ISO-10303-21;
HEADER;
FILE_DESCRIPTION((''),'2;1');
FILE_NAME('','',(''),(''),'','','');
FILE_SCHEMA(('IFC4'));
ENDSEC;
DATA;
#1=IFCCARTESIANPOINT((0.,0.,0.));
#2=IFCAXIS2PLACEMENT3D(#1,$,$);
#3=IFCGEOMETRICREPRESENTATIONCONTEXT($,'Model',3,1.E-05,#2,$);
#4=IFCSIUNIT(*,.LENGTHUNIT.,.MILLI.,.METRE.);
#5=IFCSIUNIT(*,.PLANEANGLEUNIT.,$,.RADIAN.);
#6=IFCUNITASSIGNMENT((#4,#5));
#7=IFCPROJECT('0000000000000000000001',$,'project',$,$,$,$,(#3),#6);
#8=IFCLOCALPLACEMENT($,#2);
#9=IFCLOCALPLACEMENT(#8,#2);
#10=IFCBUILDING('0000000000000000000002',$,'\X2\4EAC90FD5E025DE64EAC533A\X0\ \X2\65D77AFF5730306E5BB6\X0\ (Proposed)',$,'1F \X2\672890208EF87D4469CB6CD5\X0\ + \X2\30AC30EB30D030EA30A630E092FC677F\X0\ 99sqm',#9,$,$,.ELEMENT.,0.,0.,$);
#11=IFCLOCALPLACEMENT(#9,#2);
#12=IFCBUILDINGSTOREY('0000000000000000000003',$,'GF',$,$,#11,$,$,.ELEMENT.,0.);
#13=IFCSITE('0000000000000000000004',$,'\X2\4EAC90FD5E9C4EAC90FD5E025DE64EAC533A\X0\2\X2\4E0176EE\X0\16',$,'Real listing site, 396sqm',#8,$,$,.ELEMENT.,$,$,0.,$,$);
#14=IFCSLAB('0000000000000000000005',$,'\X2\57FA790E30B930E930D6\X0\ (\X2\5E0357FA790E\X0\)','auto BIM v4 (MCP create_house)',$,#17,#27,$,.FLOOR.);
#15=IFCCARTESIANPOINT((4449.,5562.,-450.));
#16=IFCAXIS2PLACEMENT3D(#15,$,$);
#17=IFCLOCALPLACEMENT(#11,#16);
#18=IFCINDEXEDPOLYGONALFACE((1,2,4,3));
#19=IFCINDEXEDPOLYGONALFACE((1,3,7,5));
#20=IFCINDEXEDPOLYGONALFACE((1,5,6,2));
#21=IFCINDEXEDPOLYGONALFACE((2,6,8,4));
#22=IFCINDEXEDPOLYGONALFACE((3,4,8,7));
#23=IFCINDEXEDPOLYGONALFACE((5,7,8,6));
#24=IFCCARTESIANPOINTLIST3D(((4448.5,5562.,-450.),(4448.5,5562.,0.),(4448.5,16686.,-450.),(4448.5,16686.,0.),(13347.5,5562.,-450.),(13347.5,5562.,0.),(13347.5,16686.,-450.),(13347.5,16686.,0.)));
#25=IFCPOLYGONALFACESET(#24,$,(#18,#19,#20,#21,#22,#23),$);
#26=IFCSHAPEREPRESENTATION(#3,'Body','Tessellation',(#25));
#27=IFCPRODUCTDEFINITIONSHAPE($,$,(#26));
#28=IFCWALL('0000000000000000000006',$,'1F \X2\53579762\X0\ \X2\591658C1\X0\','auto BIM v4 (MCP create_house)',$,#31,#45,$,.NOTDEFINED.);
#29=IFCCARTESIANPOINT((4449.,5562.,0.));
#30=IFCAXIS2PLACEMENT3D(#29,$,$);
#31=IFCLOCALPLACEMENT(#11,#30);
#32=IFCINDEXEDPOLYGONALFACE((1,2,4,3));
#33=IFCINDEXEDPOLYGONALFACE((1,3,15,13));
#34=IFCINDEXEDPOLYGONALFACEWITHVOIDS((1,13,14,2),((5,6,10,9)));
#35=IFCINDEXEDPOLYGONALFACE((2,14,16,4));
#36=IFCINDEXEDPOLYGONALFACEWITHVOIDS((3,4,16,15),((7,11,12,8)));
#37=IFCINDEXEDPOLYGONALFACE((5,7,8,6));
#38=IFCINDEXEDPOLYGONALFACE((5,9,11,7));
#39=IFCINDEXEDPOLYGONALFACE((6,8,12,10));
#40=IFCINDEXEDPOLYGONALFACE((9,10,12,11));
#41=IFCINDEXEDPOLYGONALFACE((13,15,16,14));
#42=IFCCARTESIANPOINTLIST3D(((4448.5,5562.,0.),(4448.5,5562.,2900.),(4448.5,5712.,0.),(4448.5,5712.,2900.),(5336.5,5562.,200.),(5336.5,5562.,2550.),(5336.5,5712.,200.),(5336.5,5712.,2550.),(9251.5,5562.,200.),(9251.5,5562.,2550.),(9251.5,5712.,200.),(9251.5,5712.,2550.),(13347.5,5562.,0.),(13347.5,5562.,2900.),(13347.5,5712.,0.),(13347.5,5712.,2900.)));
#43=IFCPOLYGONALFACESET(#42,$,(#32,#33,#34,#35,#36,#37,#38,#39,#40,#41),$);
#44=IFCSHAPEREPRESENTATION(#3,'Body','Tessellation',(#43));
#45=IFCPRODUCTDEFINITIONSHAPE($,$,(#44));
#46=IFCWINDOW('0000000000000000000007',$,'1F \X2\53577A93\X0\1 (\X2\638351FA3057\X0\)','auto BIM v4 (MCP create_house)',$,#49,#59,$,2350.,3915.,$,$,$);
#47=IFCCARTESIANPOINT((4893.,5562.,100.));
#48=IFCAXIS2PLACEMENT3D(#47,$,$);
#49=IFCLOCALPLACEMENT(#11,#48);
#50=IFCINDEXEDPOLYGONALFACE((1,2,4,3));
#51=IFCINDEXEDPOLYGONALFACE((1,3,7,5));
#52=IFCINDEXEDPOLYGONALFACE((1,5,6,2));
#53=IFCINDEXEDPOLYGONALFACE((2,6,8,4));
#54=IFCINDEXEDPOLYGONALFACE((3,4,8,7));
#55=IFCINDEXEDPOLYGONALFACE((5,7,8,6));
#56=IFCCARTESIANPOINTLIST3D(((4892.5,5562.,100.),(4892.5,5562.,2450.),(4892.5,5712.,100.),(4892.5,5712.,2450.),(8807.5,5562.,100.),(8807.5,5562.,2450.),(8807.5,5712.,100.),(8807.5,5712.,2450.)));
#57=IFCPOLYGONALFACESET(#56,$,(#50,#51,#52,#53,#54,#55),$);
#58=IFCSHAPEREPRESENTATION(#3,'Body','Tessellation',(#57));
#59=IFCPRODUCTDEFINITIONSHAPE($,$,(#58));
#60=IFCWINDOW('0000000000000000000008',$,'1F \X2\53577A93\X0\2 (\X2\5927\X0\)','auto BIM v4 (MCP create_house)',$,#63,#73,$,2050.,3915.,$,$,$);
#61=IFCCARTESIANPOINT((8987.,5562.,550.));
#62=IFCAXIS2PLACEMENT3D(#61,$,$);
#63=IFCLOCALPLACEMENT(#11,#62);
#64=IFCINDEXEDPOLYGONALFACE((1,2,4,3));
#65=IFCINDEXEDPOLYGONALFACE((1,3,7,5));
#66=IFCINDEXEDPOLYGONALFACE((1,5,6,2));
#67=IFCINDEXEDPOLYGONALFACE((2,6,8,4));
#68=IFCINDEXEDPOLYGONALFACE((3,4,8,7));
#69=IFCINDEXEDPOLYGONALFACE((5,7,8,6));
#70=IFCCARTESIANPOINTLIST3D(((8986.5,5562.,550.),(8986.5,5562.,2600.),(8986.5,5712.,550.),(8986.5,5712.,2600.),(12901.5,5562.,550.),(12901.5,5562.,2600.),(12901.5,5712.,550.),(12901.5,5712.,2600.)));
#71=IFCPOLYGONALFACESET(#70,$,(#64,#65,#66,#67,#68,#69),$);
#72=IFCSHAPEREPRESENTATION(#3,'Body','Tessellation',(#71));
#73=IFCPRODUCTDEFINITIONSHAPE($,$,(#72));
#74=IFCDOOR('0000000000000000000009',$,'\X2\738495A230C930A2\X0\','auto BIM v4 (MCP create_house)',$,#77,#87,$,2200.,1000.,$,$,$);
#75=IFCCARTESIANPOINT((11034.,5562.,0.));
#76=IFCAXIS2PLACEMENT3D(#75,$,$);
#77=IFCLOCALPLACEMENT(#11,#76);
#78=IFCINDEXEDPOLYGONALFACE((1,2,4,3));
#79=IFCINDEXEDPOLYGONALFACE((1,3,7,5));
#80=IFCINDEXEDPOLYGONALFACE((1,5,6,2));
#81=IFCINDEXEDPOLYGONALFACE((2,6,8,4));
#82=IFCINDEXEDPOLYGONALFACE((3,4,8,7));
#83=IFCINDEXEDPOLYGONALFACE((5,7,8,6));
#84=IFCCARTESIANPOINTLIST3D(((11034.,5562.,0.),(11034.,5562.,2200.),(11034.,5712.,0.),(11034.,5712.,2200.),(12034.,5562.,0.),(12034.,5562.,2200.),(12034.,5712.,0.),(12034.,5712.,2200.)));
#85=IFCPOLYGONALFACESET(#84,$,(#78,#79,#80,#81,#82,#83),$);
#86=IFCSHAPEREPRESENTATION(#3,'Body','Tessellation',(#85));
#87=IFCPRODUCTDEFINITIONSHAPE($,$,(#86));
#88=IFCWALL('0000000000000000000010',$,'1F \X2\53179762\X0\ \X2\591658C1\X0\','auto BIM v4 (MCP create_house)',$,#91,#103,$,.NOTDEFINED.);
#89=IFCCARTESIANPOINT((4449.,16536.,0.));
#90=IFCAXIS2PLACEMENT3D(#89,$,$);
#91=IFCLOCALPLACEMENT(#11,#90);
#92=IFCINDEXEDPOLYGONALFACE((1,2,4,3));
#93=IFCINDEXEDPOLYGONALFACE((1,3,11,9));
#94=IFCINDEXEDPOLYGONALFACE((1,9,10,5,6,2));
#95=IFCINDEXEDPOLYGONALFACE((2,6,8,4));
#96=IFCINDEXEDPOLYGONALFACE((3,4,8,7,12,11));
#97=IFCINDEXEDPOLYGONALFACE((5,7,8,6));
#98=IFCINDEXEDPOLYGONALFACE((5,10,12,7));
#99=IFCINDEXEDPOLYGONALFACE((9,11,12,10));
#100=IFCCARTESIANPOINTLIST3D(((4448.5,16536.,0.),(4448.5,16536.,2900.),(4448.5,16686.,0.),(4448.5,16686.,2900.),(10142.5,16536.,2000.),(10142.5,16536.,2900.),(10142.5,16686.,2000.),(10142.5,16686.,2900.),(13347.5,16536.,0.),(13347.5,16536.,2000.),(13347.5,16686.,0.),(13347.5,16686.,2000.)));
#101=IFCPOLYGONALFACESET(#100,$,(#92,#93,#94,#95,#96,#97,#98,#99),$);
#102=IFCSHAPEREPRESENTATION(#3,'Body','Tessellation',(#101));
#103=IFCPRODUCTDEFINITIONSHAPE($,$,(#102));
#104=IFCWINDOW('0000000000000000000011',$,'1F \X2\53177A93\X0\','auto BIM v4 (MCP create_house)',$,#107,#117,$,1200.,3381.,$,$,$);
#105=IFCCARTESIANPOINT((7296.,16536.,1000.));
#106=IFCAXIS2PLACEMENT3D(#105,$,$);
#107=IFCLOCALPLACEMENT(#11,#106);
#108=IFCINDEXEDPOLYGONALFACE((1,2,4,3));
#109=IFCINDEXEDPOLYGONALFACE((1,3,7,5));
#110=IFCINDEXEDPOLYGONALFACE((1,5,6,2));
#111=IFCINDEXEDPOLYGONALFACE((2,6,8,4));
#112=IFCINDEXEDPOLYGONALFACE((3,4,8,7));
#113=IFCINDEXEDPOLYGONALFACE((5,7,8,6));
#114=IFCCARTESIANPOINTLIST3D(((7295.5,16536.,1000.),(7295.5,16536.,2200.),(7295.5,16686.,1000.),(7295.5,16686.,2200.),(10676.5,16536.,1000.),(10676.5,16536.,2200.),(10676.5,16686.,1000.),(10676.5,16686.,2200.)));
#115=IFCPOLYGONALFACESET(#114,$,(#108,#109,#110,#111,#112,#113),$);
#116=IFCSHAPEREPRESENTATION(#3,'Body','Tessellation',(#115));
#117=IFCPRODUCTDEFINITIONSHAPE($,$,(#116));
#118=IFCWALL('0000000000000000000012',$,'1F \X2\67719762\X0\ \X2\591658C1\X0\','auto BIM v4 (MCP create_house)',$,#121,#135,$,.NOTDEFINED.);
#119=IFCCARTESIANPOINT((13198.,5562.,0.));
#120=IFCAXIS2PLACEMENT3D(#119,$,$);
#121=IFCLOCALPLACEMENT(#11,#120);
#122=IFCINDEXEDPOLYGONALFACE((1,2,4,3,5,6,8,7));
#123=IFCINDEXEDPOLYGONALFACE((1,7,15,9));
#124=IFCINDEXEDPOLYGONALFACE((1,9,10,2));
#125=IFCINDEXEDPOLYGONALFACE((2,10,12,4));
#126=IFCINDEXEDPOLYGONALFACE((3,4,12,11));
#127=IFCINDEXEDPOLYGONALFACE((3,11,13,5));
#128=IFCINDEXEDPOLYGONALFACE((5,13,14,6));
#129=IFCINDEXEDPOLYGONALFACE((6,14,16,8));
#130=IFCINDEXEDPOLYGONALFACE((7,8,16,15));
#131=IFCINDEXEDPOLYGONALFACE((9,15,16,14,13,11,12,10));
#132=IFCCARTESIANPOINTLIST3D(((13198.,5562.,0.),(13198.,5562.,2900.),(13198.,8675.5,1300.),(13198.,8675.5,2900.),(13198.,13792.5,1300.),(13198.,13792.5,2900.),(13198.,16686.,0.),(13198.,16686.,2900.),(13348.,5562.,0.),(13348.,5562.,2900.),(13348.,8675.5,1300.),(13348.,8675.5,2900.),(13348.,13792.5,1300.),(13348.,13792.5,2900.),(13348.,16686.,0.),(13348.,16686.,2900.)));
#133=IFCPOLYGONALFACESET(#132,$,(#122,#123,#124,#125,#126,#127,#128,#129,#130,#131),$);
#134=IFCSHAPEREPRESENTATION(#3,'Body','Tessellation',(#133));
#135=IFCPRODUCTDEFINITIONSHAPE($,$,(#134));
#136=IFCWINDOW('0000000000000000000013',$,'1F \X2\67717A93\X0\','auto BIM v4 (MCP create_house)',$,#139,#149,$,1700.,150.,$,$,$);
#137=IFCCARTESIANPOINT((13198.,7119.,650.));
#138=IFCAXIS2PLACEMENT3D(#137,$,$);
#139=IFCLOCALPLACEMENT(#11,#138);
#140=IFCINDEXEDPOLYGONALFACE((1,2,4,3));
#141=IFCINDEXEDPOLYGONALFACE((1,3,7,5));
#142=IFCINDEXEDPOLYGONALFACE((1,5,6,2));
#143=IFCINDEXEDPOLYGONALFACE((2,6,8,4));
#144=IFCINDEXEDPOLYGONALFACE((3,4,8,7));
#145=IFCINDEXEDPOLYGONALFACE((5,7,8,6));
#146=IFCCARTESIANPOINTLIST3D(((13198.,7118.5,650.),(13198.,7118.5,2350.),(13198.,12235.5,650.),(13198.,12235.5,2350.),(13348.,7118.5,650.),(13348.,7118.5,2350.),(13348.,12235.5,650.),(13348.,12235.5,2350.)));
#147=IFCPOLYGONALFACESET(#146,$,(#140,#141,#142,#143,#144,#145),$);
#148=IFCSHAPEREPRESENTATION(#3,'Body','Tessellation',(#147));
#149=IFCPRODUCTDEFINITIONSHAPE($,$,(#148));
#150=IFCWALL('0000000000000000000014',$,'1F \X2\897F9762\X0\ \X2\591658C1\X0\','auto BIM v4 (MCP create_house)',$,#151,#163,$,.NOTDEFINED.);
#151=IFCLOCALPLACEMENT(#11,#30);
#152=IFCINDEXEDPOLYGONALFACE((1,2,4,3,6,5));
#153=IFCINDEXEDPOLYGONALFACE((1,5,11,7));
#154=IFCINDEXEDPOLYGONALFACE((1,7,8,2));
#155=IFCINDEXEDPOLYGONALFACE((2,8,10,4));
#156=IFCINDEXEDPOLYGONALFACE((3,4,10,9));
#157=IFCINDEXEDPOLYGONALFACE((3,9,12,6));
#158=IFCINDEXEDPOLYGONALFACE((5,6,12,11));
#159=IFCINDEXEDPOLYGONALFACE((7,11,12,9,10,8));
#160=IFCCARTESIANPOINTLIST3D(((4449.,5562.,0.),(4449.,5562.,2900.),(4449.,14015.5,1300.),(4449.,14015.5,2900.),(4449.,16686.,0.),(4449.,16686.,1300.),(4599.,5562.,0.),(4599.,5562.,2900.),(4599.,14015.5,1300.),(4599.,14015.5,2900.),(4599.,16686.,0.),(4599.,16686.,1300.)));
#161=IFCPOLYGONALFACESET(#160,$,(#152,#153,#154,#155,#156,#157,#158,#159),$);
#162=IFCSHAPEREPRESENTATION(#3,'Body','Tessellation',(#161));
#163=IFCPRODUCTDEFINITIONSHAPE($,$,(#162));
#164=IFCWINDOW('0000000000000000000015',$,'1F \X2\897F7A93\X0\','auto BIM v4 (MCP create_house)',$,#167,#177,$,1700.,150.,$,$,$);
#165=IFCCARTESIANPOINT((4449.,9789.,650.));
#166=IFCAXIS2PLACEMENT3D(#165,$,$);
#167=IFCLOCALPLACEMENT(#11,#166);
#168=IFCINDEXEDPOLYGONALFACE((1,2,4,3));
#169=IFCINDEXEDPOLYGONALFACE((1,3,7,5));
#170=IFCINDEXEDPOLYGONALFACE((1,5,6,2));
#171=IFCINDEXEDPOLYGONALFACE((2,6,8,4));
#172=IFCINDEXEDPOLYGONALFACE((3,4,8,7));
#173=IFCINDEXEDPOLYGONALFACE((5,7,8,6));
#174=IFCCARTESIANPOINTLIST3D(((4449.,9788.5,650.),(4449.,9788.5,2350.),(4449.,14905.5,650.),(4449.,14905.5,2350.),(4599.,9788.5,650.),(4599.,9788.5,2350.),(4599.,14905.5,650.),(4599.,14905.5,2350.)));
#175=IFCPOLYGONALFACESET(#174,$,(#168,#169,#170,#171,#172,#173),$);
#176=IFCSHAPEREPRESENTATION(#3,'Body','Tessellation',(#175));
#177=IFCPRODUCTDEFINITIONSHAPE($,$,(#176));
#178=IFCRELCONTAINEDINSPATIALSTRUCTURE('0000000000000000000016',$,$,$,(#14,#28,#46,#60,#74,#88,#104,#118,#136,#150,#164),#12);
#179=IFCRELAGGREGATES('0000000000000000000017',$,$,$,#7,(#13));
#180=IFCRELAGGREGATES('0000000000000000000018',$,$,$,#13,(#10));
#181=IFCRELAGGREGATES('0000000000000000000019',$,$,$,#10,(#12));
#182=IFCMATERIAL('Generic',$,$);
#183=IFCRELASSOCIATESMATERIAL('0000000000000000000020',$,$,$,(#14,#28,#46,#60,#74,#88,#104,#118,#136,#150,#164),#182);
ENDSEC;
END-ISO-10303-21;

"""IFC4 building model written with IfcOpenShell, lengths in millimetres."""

from ifc_helpers import new_model, si_unit, frame, frame_2d, origin, place, context, project, spatial, rectangle, extrude, material, element, fill, save


model = new_model("IFC4")

# Units and contexts
model_context = context("Model", 3, precision=1e-05, world=origin())
ifc_project = project(units=[si_unit("LENGTHUNIT", "METRE", prefix="MILLI"), si_unit("PLANEANGLEUNIT", "RADIAN")], contexts=[model_context])

# Site, building, storey
site_placement = place(None, origin())
site = spatial("IfcSite", under=ifc_project, at=site_placement, Name="京都府京都市左京区2丁目16", ObjectType="Real listing site, 396sqm", CompositionType="ELEMENT", RefElevation=0.0)
building_placement = place(site_placement, origin())
building = spatial("IfcBuilding", under=site, at=building_placement, Name="京都市左京区 旗竿地の家 (Proposed)", ObjectType="1F 木造軸組構法 + ガルバリウム鋼板 99sqm", CompositionType="ELEMENT", ElevationOfRefHeight=0.0, ElevationOfTerrain=0.0)
storey_placement = place(building_placement, origin())
storey = spatial("IfcBuildingStorey", under=building, at=storey_placement, Name="GF", CompositionType="ELEMENT", Elevation=0.0)

# Slab
ifc_material = material(Name="Generic")
slab_1_placement = place(storey_placement, frame((4449.0, 5562.0, -450.0)))
element("IfcSlab", 1, at=slab_1_placement, inside=storey, material=ifc_material, Name="基礎スラブ (布基礎)", Description="auto BIM v4 (MCP create_house)", PredefinedType="FLOOR", context=model_context, shape_type="SweptSolid", body=[
    extrude(rectangle(XDim=8899.0, YDim=11124.0, at=frame_2d((4449.0, 5562.0))), frame((4449.0, 5562.0, -450.0)), (0.0, 0.0, 1.0), 450.0),
])

# Wall, openings, windows, door
wall_1_placement = place(storey_placement, frame((4449.0, 5562.0, 0.0)))
wall_1 = element("IfcWall", 2, at=wall_1_placement, inside=storey, material=ifc_material, Name="1F 南面 外壁", Description="auto BIM v4 (MCP create_house)", PredefinedType="NOTDEFINED", context=model_context, shape_type="SweptSolid", body=[
    extrude(rectangle(XDim=8899.0, YDim=150.0, at=frame_2d((4449.0, 75.0))), frame((4449.0, 5562.0, 0.0)), (0.0, 0.0, 1.0), 2900.0),
])
opening_1_placement = place(storey_placement, frame((4893.0, 5562.0, 100.0)))
opening_1 = element("IfcOpeningElement", 3, at=opening_1_placement, cuts=wall_1, PredefinedType="NOTDEFINED", context=model_context, shape_type="SweptSolid", body=[
    extrude(rectangle(XDim=3915.0, YDim=150.0, at=frame_2d((1957.0, 75.0))), frame((4893.0, 5562.0, 100.0)), (0.0, 0.0, 1.0), 2350.0),
])
opening_2_placement = place(storey_placement, frame((8987.0, 5562.0, 550.0)))
opening_2 = element("IfcOpeningElement", 4, at=opening_2_placement, cuts=wall_1, PredefinedType="NOTDEFINED", context=model_context, shape_type="SweptSolid", body=[
    extrude(rectangle(XDim=3915.0, YDim=150.0, at=frame_2d((1957.0, 75.0))), frame((8987.0, 5562.0, 550.0)), (0.0, 0.0, 1.0), 2050.0),
])
opening_3_placement = place(storey_placement, frame((11034.0, 5562.0, 0.0)))
opening_3 = element("IfcOpeningElement", 5, at=opening_3_placement, cuts=wall_1, PredefinedType="NOTDEFINED", context=model_context, shape_type="SweptSolid", body=[
    extrude(rectangle(XDim=1000.0, YDim=150.0, at=frame_2d((500.0, 75.0))), frame((11034.0, 5562.0, 0.0)), (0.0, 0.0, 1.0), 2200.0),
])
window_1_placement = place(storey_placement, frame((4893.0, 5562.0, 100.0)))
window_1 = element("IfcWindow", 6, at=window_1_placement, inside=storey, material=ifc_material, Name="1F 南窓1 (掃出し)", Description="auto BIM v4 (MCP create_house)", OverallHeight=2350.0, OverallWidth=3915.0, context=model_context, shape_type="SweptSolid", body=[
    extrude(rectangle(XDim=3915.0, YDim=150.0, at=frame_2d((1957.0, 75.0))), frame((4893.0, 5562.0, 100.0)), (0.0, 0.0, 1.0), 2350.0),
])
fill(opening_1, window_1)
window_2_placement = place(storey_placement, frame((8987.0, 5562.0, 550.0)))
window_2 = element("IfcWindow", 7, at=window_2_placement, inside=storey, material=ifc_material, Name="1F 南窓2 (大)", Description="auto BIM v4 (MCP create_house)", OverallHeight=2050.0, OverallWidth=3915.0, context=model_context, shape_type="SweptSolid", body=[
    extrude(rectangle(XDim=3915.0, YDim=150.0, at=frame_2d((1957.0, 75.0))), frame((8987.0, 5562.0, 550.0)), (0.0, 0.0, 1.0), 2050.0),
])
fill(opening_2, window_2)
door_placement = place(storey_placement, frame((11034.0, 5562.0, 0.0)))
door = element("IfcDoor", 8, at=door_placement, inside=storey, material=ifc_material, Name="玄関ドア", Description="auto BIM v4 (MCP create_house)", OverallHeight=2200.0, OverallWidth=1000.0, context=model_context, shape_type="SweptSolid", body=[
    extrude(rectangle(XDim=1000.0, YDim=150.0, at=frame_2d((500.0, 75.0))), frame((11034.0, 5562.0, 0.0)), (0.0, 0.0, 1.0), 2200.0),
])
fill(opening_3, door)

# Walls, openings, windows
wall_2_placement = place(storey_placement, frame((4449.0, 16536.0, 0.0)))
wall_2 = element("IfcWall", 9, at=wall_2_placement, inside=storey, material=ifc_material, Name="1F 北面 外壁", Description="auto BIM v4 (MCP create_house)", PredefinedType="NOTDEFINED", context=model_context, shape_type="SweptSolid", body=[
    extrude(rectangle(XDim=8899.0, YDim=150.0, at=frame_2d((4449.0, 75.0))), frame((4449.0, 16536.0, 0.0)), (0.0, 0.0, 1.0), 2900.0),
])
opening_4_placement = place(storey_placement, frame((7296.0, 16536.0, 1000.0)))
opening_4 = element("IfcOpeningElement", 10, at=opening_4_placement, cuts=wall_2, PredefinedType="NOTDEFINED", context=model_context, shape_type="SweptSolid", body=[
    extrude(rectangle(XDim=3381.0, YDim=150.0, at=frame_2d((1690.0, 75.0))), frame((7296.0, 16536.0, 1000.0)), (0.0, 0.0, 1.0), 1200.0),
])
window_3_placement = place(storey_placement, frame((7296.0, 16536.0, 1000.0)))
window_3 = element("IfcWindow", 11, at=window_3_placement, inside=storey, material=ifc_material, Name="1F 北窓", Description="auto BIM v4 (MCP create_house)", OverallHeight=1200.0, OverallWidth=3381.0, context=model_context, shape_type="SweptSolid", body=[
    extrude(rectangle(XDim=3381.0, YDim=150.0, at=frame_2d((1690.0, 75.0))), frame((7296.0, 16536.0, 1000.0)), (0.0, 0.0, 1.0), 1200.0),
])
fill(opening_4, window_3)
wall_3_placement = place(storey_placement, frame((13198.0, 5562.0, 0.0)))
wall_3 = element("IfcWall", 12, at=wall_3_placement, inside=storey, material=ifc_material, Name="1F 東面 外壁", Description="auto BIM v4 (MCP create_house)", PredefinedType="NOTDEFINED", context=model_context, shape_type="SweptSolid", body=[
    extrude(rectangle(XDim=150.0, YDim=11124.0, at=frame_2d((75.0, 5562.0))), frame((13198.0, 5562.0, 0.0)), (0.0, 0.0, 1.0), 2900.0),
])
opening_5_placement = place(storey_placement, frame((13198.0, 7119.0, 650.0)))
opening_5 = element("IfcOpeningElement", 13, at=opening_5_placement, cuts=wall_3, PredefinedType="NOTDEFINED", context=model_context, shape_type="SweptSolid", body=[
    extrude(rectangle(XDim=150.0, YDim=5117.0, at=frame_2d((75.0, 2558.0))), frame((13198.0, 7119.0, 650.0)), (0.0, 0.0, 1.0), 1700.0),
])
window_4_placement = place(storey_placement, frame((13198.0, 7119.0, 650.0)))
window_4 = element("IfcWindow", 14, at=window_4_placement, inside=storey, material=ifc_material, Name="1F 東窓", Description="auto BIM v4 (MCP create_house)", OverallHeight=1700.0, OverallWidth=150.0, context=model_context, shape_type="SweptSolid", body=[
    extrude(rectangle(XDim=150.0, YDim=5117.0, at=frame_2d((75.0, 2558.0))), frame((13198.0, 7119.0, 650.0)), (0.0, 0.0, 1.0), 1700.0),
])
fill(opening_5, window_4)
wall_4_placement = place(storey_placement, frame((4449.0, 5562.0, 0.0)))
wall_4 = element("IfcWall", 15, at=wall_4_placement, inside=storey, material=ifc_material, Name="1F 西面 外壁", Description="auto BIM v4 (MCP create_house)", PredefinedType="NOTDEFINED", context=model_context, shape_type="SweptSolid", body=[
    extrude(rectangle(XDim=150.0, YDim=11124.0, at=frame_2d((75.0, 5562.0))), frame((4449.0, 5562.0, 0.0)), (0.0, 0.0, 1.0), 2900.0),
])
opening_6_placement = place(storey_placement, frame((4449.0, 9789.0, 650.0)))
opening_6 = element("IfcOpeningElement", 16, at=opening_6_placement, cuts=wall_4, PredefinedType="NOTDEFINED", context=model_context, shape_type="SweptSolid", body=[
    extrude(rectangle(XDim=150.0, YDim=5117.0, at=frame_2d((75.0, 2558.0))), frame((4449.0, 9789.0, 650.0)), (0.0, 0.0, 1.0), 1700.0),
])
window_5_placement = place(storey_placement, frame((4449.0, 9789.0, 650.0)))
window_5 = element("IfcWindow", 17, at=window_5_placement, inside=storey, material=ifc_material, Name="1F 西窓", Description="auto BIM v4 (MCP create_house)", OverallHeight=1700.0, OverallWidth=150.0, context=model_context, shape_type="SweptSolid", body=[
    extrude(rectangle(XDim=150.0, YDim=5117.0, at=frame_2d((75.0, 2558.0))), frame((4449.0, 9789.0, 650.0)), (0.0, 0.0, 1.0), 1700.0),
])
fill(opening_6, window_5)

save(model, "model.ifc")
